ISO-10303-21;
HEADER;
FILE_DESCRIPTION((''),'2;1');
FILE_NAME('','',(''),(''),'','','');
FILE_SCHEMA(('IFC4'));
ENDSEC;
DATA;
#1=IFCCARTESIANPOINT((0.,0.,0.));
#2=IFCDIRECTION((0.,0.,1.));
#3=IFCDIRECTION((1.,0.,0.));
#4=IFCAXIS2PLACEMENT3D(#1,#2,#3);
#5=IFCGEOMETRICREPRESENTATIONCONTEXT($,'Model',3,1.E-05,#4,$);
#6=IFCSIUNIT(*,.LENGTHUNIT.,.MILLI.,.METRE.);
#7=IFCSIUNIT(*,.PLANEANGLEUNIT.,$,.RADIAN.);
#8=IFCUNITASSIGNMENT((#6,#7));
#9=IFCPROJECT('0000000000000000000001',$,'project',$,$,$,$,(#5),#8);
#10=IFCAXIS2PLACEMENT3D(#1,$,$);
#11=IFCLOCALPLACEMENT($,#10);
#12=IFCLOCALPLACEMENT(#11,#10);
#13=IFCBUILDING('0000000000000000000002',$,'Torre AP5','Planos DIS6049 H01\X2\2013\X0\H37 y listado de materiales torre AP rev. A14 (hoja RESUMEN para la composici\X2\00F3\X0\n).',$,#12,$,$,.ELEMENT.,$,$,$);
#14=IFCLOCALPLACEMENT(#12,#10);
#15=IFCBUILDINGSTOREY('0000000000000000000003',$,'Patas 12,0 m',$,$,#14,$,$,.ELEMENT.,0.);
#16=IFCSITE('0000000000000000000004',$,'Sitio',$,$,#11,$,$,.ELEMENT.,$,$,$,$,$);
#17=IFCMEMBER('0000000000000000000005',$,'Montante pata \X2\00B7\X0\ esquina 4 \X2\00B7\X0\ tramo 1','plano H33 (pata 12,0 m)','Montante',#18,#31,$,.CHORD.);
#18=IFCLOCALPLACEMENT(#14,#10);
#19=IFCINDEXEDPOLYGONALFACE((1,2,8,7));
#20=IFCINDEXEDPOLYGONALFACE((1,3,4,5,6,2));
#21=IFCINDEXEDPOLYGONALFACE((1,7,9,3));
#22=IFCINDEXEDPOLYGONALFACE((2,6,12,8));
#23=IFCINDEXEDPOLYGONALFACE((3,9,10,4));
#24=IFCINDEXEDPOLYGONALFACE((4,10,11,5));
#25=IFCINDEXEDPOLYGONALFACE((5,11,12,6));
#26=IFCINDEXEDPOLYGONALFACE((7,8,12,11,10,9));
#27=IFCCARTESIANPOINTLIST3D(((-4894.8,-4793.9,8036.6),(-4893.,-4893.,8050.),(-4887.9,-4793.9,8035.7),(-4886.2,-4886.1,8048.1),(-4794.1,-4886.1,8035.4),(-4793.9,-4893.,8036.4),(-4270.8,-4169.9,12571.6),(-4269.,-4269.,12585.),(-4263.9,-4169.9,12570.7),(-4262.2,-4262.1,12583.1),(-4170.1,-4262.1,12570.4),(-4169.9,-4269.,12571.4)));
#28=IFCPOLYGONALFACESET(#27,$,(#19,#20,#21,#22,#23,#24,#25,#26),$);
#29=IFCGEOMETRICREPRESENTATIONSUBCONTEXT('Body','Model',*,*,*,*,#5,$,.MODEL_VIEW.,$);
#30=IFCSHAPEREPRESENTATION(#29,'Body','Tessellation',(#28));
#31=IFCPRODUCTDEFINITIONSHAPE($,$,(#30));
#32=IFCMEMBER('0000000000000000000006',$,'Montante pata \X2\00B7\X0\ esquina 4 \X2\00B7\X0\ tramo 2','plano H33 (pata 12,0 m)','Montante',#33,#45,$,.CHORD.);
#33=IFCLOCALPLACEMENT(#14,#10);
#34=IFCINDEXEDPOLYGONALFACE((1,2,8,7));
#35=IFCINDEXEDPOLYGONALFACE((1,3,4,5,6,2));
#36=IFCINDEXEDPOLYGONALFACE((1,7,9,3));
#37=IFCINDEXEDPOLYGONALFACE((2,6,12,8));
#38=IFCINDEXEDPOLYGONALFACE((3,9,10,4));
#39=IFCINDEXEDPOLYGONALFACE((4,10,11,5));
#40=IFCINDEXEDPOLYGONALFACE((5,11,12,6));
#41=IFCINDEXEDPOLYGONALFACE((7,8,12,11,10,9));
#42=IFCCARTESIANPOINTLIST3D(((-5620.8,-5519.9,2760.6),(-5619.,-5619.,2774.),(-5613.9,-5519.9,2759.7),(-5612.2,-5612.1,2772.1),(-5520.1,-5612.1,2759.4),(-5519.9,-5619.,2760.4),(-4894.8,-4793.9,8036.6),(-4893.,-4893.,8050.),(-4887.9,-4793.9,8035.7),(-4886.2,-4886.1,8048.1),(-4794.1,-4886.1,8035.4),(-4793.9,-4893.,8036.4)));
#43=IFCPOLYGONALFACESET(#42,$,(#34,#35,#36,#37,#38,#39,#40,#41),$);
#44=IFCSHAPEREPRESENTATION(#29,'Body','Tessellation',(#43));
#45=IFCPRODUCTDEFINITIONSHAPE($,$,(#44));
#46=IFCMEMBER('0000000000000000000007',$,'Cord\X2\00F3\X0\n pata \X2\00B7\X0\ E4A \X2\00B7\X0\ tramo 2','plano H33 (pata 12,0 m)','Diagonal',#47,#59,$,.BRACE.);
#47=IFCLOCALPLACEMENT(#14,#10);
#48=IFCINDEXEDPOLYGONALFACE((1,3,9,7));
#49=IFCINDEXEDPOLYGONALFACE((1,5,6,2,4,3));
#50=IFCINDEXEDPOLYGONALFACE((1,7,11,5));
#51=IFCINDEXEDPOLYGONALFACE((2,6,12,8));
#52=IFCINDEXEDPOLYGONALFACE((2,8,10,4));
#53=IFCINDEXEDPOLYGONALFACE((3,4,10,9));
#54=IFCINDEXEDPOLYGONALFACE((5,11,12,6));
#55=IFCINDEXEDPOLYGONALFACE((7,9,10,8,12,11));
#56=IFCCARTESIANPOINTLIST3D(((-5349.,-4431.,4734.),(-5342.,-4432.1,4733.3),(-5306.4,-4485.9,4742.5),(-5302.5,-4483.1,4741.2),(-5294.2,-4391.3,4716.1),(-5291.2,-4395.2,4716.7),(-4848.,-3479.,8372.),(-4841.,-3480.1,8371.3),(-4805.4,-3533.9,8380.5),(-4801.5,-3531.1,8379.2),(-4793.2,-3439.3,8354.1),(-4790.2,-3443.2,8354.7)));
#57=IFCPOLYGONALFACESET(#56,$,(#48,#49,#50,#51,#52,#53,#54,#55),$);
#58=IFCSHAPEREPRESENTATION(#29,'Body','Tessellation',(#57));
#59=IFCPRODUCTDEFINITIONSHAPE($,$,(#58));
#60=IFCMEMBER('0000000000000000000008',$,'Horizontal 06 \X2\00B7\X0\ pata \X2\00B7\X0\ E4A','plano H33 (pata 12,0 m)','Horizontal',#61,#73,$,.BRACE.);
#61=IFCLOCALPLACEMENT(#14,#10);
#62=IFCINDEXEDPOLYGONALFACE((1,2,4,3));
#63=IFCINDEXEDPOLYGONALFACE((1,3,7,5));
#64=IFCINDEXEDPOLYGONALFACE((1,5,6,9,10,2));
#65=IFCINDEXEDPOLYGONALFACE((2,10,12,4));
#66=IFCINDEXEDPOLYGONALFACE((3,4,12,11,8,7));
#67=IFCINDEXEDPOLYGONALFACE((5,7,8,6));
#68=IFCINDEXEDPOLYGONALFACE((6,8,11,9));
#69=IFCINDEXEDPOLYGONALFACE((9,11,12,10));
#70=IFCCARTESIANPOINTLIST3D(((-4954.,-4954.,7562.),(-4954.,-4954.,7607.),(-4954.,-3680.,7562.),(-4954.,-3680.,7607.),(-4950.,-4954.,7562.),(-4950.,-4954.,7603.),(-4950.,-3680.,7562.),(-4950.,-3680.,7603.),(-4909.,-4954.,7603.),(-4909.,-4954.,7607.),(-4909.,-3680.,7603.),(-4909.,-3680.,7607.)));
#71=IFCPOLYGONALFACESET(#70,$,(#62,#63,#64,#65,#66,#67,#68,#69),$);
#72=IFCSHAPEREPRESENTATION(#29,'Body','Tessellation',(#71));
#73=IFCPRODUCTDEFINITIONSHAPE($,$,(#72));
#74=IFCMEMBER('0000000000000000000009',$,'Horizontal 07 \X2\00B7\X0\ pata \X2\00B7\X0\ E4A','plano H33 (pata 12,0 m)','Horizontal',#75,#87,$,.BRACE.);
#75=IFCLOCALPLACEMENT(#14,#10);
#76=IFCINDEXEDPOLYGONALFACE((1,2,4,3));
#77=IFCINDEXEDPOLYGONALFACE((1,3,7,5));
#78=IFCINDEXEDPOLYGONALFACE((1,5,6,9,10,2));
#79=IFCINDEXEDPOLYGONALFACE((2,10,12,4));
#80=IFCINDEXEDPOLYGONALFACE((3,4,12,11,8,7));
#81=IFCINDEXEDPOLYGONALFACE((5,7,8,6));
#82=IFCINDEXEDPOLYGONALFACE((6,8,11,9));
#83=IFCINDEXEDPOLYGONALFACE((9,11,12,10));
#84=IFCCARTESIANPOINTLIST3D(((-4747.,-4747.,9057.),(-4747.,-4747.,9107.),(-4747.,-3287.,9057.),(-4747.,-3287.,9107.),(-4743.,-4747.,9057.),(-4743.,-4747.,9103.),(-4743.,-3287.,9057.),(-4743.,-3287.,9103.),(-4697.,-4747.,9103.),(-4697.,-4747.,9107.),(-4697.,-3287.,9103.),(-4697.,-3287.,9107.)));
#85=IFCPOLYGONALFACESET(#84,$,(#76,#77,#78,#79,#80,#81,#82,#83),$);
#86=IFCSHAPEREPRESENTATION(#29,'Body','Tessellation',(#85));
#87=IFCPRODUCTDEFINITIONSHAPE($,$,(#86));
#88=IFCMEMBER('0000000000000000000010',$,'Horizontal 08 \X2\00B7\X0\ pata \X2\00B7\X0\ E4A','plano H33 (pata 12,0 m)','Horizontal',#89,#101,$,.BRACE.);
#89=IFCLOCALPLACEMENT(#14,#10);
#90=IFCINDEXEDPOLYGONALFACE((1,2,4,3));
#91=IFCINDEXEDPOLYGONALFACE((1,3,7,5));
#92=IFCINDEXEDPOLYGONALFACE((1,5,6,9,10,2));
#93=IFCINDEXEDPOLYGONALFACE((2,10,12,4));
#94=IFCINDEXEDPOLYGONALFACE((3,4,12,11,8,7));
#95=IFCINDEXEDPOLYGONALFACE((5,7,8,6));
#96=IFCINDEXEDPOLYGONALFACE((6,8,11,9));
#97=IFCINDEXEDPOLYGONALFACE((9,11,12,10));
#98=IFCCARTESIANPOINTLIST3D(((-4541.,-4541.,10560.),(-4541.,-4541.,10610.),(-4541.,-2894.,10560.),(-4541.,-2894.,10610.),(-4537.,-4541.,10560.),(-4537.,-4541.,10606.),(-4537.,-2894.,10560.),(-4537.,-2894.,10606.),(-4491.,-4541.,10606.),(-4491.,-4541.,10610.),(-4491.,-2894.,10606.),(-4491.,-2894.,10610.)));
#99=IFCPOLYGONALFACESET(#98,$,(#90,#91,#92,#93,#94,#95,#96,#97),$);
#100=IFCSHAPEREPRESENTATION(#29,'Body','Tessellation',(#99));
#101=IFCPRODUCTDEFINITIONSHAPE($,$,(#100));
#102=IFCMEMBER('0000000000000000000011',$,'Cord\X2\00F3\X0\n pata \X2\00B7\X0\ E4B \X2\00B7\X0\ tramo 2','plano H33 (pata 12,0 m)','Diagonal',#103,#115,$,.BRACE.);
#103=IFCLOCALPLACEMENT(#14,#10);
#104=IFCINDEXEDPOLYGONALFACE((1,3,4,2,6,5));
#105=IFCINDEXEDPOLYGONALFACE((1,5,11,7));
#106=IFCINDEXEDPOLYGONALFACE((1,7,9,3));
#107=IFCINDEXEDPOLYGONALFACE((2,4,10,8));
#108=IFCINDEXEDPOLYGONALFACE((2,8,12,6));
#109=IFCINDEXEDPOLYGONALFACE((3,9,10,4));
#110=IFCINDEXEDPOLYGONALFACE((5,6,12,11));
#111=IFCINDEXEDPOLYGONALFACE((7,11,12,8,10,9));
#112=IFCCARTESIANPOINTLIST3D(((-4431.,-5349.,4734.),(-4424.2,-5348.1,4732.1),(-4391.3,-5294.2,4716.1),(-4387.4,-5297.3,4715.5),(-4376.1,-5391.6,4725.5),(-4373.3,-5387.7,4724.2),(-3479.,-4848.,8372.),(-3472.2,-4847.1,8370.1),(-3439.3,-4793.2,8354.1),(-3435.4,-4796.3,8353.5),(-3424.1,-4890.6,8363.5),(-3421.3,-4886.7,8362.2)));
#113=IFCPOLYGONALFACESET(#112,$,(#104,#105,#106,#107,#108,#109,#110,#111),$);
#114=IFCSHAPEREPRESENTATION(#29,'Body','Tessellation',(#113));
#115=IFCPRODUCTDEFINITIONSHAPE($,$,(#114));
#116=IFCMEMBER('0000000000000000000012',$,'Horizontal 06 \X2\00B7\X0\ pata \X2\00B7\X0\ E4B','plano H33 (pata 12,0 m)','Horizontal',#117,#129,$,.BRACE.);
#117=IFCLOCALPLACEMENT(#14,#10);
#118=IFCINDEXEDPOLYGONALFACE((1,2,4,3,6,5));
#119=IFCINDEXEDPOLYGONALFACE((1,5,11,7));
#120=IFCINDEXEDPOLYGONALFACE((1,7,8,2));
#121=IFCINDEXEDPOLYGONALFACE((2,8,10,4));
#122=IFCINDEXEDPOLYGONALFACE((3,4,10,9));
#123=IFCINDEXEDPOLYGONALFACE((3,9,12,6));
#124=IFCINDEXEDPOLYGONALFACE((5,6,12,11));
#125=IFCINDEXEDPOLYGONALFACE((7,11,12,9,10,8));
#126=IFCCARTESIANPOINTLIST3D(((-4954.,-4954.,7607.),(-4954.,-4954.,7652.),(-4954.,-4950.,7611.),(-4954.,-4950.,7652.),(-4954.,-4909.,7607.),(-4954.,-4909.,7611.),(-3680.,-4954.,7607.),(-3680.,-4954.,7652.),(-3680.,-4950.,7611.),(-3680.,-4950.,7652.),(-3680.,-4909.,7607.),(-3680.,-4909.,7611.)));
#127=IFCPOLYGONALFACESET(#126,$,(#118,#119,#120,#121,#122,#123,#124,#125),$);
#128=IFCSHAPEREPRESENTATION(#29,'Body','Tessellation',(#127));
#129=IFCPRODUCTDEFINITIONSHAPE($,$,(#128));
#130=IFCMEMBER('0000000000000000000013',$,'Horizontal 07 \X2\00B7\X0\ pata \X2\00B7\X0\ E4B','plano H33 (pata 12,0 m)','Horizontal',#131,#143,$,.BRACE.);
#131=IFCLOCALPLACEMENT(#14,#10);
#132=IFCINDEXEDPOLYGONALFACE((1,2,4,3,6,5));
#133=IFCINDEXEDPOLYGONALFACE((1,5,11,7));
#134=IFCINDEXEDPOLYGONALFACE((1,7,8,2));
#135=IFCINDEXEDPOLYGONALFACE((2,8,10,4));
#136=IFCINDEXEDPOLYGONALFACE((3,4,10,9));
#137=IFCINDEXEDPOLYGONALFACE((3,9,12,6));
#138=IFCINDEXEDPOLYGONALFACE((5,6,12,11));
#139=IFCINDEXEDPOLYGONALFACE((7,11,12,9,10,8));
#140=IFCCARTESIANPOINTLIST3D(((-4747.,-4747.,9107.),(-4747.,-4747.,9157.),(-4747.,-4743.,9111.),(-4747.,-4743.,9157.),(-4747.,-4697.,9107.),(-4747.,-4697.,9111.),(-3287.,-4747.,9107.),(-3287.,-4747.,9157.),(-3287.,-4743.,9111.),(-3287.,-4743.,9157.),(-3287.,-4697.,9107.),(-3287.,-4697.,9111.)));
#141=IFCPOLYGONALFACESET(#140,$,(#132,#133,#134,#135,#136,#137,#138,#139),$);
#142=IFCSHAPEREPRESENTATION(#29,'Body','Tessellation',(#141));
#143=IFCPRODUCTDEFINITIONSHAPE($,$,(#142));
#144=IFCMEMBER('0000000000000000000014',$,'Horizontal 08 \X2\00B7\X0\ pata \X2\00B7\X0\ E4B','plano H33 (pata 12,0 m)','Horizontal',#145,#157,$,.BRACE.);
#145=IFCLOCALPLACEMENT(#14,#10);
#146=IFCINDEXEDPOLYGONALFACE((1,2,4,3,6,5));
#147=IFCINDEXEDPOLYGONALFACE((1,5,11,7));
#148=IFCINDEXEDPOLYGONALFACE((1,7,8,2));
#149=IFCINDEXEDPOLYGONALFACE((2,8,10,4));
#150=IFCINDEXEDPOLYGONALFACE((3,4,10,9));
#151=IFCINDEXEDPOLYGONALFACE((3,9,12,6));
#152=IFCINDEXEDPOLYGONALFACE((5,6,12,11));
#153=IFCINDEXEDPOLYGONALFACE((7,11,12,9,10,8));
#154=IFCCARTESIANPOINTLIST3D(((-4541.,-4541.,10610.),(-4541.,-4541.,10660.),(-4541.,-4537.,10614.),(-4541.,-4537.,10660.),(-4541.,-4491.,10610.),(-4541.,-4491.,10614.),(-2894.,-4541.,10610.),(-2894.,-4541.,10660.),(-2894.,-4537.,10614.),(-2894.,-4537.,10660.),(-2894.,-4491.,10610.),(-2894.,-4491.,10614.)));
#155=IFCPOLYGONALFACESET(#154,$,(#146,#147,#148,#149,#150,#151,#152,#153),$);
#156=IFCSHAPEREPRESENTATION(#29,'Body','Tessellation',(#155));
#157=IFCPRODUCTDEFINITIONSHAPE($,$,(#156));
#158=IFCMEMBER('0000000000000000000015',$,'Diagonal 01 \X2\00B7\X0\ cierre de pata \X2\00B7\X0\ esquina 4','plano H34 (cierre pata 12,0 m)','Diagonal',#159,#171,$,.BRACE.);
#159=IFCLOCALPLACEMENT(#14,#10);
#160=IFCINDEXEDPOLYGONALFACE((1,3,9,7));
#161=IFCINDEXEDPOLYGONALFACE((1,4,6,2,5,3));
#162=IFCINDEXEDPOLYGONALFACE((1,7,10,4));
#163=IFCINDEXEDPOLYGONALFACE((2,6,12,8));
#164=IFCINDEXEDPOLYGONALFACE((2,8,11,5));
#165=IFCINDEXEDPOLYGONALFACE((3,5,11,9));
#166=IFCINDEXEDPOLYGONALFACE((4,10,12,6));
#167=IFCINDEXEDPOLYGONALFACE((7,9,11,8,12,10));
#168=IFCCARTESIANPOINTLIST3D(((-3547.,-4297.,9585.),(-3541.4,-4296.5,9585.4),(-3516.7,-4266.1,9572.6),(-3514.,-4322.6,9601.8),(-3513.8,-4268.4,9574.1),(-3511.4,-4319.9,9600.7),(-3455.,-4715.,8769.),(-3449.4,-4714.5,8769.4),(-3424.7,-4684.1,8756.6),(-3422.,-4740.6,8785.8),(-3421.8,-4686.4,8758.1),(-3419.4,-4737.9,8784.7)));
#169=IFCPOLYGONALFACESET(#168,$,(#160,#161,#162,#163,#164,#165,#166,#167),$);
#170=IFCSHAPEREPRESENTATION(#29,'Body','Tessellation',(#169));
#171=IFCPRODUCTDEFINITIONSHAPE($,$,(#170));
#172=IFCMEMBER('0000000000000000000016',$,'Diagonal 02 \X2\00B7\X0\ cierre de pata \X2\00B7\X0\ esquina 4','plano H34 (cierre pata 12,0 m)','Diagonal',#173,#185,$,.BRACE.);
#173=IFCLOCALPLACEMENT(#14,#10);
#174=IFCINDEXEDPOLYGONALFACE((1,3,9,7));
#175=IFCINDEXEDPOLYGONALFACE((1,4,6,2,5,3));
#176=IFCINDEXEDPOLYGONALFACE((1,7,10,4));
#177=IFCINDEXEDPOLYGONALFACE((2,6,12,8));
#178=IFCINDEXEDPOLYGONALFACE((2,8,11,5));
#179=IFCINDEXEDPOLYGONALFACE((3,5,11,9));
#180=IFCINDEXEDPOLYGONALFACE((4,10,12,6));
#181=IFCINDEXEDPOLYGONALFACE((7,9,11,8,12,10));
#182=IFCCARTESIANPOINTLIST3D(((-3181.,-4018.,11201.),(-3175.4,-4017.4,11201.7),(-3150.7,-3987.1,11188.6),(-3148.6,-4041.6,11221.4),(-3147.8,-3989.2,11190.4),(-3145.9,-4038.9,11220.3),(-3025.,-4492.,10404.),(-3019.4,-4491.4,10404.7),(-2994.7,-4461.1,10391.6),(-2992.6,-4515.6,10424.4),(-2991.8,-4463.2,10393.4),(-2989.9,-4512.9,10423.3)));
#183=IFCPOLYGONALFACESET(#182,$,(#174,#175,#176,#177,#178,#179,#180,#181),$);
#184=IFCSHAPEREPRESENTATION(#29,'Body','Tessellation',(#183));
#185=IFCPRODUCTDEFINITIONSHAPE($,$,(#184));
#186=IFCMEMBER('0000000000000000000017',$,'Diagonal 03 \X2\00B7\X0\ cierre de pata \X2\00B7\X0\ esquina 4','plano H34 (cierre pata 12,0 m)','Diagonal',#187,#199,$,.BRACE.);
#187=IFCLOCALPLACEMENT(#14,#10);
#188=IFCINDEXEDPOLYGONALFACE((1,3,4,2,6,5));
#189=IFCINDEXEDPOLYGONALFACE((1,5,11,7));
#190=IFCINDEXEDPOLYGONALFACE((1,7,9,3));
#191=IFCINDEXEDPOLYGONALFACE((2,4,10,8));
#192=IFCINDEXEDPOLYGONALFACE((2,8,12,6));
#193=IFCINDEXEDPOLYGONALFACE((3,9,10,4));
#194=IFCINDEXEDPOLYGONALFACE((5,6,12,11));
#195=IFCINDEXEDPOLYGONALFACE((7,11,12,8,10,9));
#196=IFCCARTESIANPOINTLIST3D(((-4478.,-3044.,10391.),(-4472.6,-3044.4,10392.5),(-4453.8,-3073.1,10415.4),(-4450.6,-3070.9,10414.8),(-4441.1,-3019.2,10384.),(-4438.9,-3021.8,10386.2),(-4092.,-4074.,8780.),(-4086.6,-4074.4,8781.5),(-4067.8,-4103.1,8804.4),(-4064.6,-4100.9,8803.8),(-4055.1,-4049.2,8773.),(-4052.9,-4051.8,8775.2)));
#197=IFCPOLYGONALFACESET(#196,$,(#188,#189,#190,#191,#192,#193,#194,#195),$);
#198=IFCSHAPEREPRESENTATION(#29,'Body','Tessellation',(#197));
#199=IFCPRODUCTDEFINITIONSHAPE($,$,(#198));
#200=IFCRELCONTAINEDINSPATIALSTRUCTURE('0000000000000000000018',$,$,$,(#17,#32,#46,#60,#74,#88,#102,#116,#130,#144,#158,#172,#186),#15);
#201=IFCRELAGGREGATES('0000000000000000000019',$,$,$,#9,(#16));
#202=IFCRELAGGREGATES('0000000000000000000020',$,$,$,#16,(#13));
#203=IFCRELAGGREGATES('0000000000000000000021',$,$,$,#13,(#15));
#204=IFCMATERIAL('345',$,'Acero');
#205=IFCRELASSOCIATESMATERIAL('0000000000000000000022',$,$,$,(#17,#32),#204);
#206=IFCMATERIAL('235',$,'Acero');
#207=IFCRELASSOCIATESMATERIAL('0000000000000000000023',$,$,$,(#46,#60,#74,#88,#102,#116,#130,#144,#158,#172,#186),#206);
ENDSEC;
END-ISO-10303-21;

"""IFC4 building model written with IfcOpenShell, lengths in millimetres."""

from ifc_helpers import new_model, si_unit, frame, frame_2d, origin, origin_with_axes, place, context, subcontext, project, spatial, l_section, extrude, material, element, save


model = new_model("IFC4")

# Units and contexts
model_context = context("Model", 3, precision=1e-05, world=origin_with_axes())
body_context = subcontext(model_context, "Body", "Model", "MODEL_VIEW")
ifc_project = project(units=[si_unit("LENGTHUNIT", "METRE", prefix="MILLI"), si_unit("PLANEANGLEUNIT", "RADIAN")], contexts=[model_context])

# Site, building, storey
site_placement = place(None, origin())
site = spatial("IfcSite", under=ifc_project, at=site_placement, Name="Sitio", CompositionType="ELEMENT")
building_placement = place(site_placement, origin())
building = spatial("IfcBuilding", under=site, at=building_placement, Name="Torre AP5", Description="Planos DIS6049 H01–H37 y listado de materiales torre AP rev. A14 (hoja RESUMEN para la composición).", CompositionType="ELEMENT")
storey_placement = place(building_placement, origin())
storey = spatial("IfcBuildingStorey", under=building, at=storey_placement, Name="Patas 12,0 m", CompositionType="ELEMENT", Elevation=0.0)

# Members
ifc_material_1 = material(Name="345", Category="Acero")
member_1_placement = place(storey_placement, frame((-4269.0, -4269.0, 12585.0), z_axis=(-0.135063, -0.135063, -0.981588), x_axis=(-0.018411, 0.990837, -0.133802)))
element("IfcMember", 1, at=member_1_placement, inside=storey, material=ifc_material_1, Name="Montante pata · esquina 4 · tramo 1", Description="plano H33 (pata 12,0 m)", ObjectType="Montante", PredefinedType="CHORD", context=body_context, shape_type="SweptSolid", body=[
    extrude(l_section(Depth=100.0, Width=100.0, Thickness=7.0, at=frame_2d((50.0, 50.0))), None, (0.0, 0.0, 1.0), 4620.1),
])
member_2_placement = place(storey_placement, frame((-4893.0, -4893.0, 8050.0), z_axis=(-0.13507, -0.13507, -0.981586), x_axis=(-0.018413, 0.990836, -0.13381)))
element("IfcMember", 2, at=member_2_placement, inside=storey, material=ifc_material_1, Name="Montante pata · esquina 4 · tramo 2", Description="plano H33 (pata 12,0 m)", ObjectType="Montante", PredefinedType="CHORD", context=body_context, shape_type="SweptSolid", body=[
    extrude(l_section(Depth=100.0, Width=100.0, Thickness=7.0, at=frame_2d((50.0, 50.0))), None, (0.0, 0.0, 1.0), 5375.0),
])
ifc_material_2 = material(Name="235", Category="Acero")
member_3_placement = place(storey_placement, frame((-4848.0, -3479.0, 8372.0), z_axis=(-0.13206, -0.250941, -0.958952), x_axis=(0.782575, 0.567377, -0.256243)))
element("IfcMember", 3, at=member_3_placement, inside=storey, material=ifc_material_2, Name="Cordón pata · E4A · tramo 2", Description="plano H33 (pata 12,0 m)", ObjectType="Diagonal", PredefinedType="BRACE", context=body_context, shape_type="SweptSolid", body=[
    extrude(l_section(Depth=70.0, Width=70.0, Thickness=5.0, at=frame_2d((35.0, 35.0))), None, (0.0, 0.0, 1.0), 3793.7),
])
member_4_placement = place(storey_placement, frame((-4954.0, -4954.0, 7607.0), z_axis=(0.0, 1.0, 0.0), x_axis=(1.0, 0.0, 0.0)))
element("IfcMember", 4, at=member_4_placement, inside=storey, material=ifc_material_2, Name="Horizontal 06 · pata · E4A", Description="plano H33 (pata 12,0 m)", ObjectType="Horizontal", PredefinedType="BRACE", context=body_context, shape_type="SweptSolid", body=[
    extrude(l_section(Depth=45.0, Width=45.0, Thickness=4.0, at=frame_2d((22.5, 22.5))), None, (0.0, 0.0, 1.0), 1274.0),
])
member_5_placement = place(storey_placement, frame((-4747.0, -4747.0, 9107.0), z_axis=(0.0, 1.0, 0.0), x_axis=(1.0, 0.0, 0.0)))
element("IfcMember", 5, at=member_5_placement, inside=storey, material=ifc_material_2, Name="Horizontal 07 · pata · E4A", Description="plano H33 (pata 12,0 m)", ObjectType="Horizontal", PredefinedType="BRACE", context=body_context, shape_type="SweptSolid", body=[
    extrude(l_section(Depth=50.0, Width=50.0, Thickness=4.0, at=frame_2d((25.0, 25.0))), None, (0.0, 0.0, 1.0), 1460.0),
])
member_6_placement = place(storey_placement, frame((-4541.0, -4541.0, 10610.0), z_axis=(0.0, 1.0, 0.0), x_axis=(1.0, 0.0, 0.0)))
element("IfcMember", 6, at=member_6_placement, inside=storey, material=ifc_material_2, Name="Horizontal 08 · pata · E4A", Description="plano H33 (pata 12,0 m)", ObjectType="Horizontal", PredefinedType="BRACE", context=body_context, shape_type="SweptSolid", body=[
    extrude(l_section(Depth=50.0, Width=50.0, Thickness=4.0, at=frame_2d((25.0, 25.0))), None, (0.0, 0.0, 1.0), 1647.0),
])
member_7_placement = place(storey_placement, frame((-3479.0, -4848.0, 8372.0), z_axis=(-0.250941, -0.13206, -0.958952), x_axis=(0.567377, 0.782575, -0.256243)))
element("IfcMember", 7, at=member_7_placement, inside=storey, material=ifc_material_2, Name="Cordón pata · E4B · tramo 2", Description="plano H33 (pata 12,0 m)", ObjectType="Diagonal", PredefinedType="BRACE", context=body_context, shape_type="SweptSolid", body=[
    extrude(l_section(Depth=70.0, Width=70.0, Thickness=5.0, at=frame_2d((35.0, 35.0))), None, (0.0, 0.0, 1.0), 3793.7),
])
member_8_placement = place(storey_placement, frame((-4954.0, -4954.0, 7607.0), z_axis=(1.0, 0.0, 0.0), x_axis=(0.0, 1.0, 0.0)))
element("IfcMember", 8, at=member_8_placement, inside=storey, material=ifc_material_2, Name="Horizontal 06 · pata · E4B", Description="plano H33 (pata 12,0 m)", ObjectType="Horizontal", PredefinedType="BRACE", context=body_context, shape_type="SweptSolid", body=[
    extrude(l_section(Depth=45.0, Width=45.0, Thickness=4.0, at=frame_2d((22.5, 22.5))), None, (0.0, 0.0, 1.0), 1274.0),
])
member_9_placement = place(storey_placement, frame((-4747.0, -4747.0, 9107.0), z_axis=(1.0, 0.0, 0.0), x_axis=(0.0, 1.0, 0.0)))
element("IfcMember", 9, at=member_9_placement, inside=storey, material=ifc_material_2, Name="Horizontal 07 · pata · E4B", Description="plano H33 (pata 12,0 m)", ObjectType="Horizontal", PredefinedType="BRACE", context=body_context, shape_type="SweptSolid", body=[
    extrude(l_section(Depth=50.0, Width=50.0, Thickness=4.0, at=frame_2d((25.0, 25.0))), None, (0.0, 0.0, 1.0), 1460.0),
])
member_10_placement = place(storey_placement, frame((-4541.0, -4541.0, 10610.0), z_axis=(1.0, 0.0, 0.0), x_axis=(0.0, 1.0, 0.0)))
element("IfcMember", 10, at=member_10_placement, inside=storey, material=ifc_material_2, Name="Horizontal 08 · pata · E4B", Description="plano H33 (pata 12,0 m)", ObjectType="Horizontal", PredefinedType="BRACE", context=body_context, shape_type="SweptSolid", body=[
    extrude(l_section(Depth=50.0, Width=50.0, Thickness=4.0, at=frame_2d((25.0, 25.0))), None, (0.0, 0.0, 1.0), 1647.0),
])
member_11_placement = place(storey_placement, frame((-3547.0, -4297.0, 9585.0), z_axis=(0.099844, -0.45364, -0.885574), x_axis=(0.673576, 0.68589, -0.275408)))
element("IfcMember", 11, at=member_11_placement, inside=storey, material=ifc_material_2, Name="Diagonal 01 · cierre de pata · esquina 4", Description="plano H34 (cierre pata 12,0 m)", ObjectType="Diagonal", PredefinedType="BRACE", context=body_context, shape_type="SweptSolid", body=[
    extrude(l_section(Depth=45.0, Width=45.0, Thickness=4.0, at=frame_2d((22.5, 22.5))), None, (0.0, 0.0, 1.0), 921.4),
])
member_12_placement = place(storey_placement, frame((-3181.0, -4018.0, 11201.0), z_axis=(0.165899, -0.504078, -0.847575), x_axis=(0.673655, 0.685615, -0.275899)))
element("IfcMember", 12, at=member_12_placement, inside=storey, material=ifc_material_2, Name="Diagonal 02 · cierre de pata · esquina 4", Description="plano H34 (cierre pata 12,0 m)", ObjectType="Diagonal", PredefinedType="BRACE", context=body_context, shape_type="SweptSolid", body=[
    extrude(l_section(Depth=45.0, Width=45.0, Thickness=4.0, at=frame_2d((22.5, 22.5))), None, (0.0, 0.0, 1.0), 940.3),
])
member_13_placement = place(storey_placement, frame((-4478.0, -3044.0, 10391.0), z_axis=(0.197878, -0.528017, -0.825859), x_axis=(0.820079, 0.550691, -0.155594)))
element("IfcMember", 13, at=member_13_placement, inside=storey, material=ifc_material_2, Name="Diagonal 03 · cierre de pata · esquina 4", Description="plano H34 (cierre pata 12,0 m)", ObjectType="Diagonal", PredefinedType="BRACE", context=body_context, shape_type="SweptSolid", body=[
    extrude(l_section(Depth=45.0, Width=45.0, Thickness=4.0, at=frame_2d((22.5, 22.5))), None, (0.0, 0.0, 1.0), 1950.7),
])

save(model, "model.ifc")
